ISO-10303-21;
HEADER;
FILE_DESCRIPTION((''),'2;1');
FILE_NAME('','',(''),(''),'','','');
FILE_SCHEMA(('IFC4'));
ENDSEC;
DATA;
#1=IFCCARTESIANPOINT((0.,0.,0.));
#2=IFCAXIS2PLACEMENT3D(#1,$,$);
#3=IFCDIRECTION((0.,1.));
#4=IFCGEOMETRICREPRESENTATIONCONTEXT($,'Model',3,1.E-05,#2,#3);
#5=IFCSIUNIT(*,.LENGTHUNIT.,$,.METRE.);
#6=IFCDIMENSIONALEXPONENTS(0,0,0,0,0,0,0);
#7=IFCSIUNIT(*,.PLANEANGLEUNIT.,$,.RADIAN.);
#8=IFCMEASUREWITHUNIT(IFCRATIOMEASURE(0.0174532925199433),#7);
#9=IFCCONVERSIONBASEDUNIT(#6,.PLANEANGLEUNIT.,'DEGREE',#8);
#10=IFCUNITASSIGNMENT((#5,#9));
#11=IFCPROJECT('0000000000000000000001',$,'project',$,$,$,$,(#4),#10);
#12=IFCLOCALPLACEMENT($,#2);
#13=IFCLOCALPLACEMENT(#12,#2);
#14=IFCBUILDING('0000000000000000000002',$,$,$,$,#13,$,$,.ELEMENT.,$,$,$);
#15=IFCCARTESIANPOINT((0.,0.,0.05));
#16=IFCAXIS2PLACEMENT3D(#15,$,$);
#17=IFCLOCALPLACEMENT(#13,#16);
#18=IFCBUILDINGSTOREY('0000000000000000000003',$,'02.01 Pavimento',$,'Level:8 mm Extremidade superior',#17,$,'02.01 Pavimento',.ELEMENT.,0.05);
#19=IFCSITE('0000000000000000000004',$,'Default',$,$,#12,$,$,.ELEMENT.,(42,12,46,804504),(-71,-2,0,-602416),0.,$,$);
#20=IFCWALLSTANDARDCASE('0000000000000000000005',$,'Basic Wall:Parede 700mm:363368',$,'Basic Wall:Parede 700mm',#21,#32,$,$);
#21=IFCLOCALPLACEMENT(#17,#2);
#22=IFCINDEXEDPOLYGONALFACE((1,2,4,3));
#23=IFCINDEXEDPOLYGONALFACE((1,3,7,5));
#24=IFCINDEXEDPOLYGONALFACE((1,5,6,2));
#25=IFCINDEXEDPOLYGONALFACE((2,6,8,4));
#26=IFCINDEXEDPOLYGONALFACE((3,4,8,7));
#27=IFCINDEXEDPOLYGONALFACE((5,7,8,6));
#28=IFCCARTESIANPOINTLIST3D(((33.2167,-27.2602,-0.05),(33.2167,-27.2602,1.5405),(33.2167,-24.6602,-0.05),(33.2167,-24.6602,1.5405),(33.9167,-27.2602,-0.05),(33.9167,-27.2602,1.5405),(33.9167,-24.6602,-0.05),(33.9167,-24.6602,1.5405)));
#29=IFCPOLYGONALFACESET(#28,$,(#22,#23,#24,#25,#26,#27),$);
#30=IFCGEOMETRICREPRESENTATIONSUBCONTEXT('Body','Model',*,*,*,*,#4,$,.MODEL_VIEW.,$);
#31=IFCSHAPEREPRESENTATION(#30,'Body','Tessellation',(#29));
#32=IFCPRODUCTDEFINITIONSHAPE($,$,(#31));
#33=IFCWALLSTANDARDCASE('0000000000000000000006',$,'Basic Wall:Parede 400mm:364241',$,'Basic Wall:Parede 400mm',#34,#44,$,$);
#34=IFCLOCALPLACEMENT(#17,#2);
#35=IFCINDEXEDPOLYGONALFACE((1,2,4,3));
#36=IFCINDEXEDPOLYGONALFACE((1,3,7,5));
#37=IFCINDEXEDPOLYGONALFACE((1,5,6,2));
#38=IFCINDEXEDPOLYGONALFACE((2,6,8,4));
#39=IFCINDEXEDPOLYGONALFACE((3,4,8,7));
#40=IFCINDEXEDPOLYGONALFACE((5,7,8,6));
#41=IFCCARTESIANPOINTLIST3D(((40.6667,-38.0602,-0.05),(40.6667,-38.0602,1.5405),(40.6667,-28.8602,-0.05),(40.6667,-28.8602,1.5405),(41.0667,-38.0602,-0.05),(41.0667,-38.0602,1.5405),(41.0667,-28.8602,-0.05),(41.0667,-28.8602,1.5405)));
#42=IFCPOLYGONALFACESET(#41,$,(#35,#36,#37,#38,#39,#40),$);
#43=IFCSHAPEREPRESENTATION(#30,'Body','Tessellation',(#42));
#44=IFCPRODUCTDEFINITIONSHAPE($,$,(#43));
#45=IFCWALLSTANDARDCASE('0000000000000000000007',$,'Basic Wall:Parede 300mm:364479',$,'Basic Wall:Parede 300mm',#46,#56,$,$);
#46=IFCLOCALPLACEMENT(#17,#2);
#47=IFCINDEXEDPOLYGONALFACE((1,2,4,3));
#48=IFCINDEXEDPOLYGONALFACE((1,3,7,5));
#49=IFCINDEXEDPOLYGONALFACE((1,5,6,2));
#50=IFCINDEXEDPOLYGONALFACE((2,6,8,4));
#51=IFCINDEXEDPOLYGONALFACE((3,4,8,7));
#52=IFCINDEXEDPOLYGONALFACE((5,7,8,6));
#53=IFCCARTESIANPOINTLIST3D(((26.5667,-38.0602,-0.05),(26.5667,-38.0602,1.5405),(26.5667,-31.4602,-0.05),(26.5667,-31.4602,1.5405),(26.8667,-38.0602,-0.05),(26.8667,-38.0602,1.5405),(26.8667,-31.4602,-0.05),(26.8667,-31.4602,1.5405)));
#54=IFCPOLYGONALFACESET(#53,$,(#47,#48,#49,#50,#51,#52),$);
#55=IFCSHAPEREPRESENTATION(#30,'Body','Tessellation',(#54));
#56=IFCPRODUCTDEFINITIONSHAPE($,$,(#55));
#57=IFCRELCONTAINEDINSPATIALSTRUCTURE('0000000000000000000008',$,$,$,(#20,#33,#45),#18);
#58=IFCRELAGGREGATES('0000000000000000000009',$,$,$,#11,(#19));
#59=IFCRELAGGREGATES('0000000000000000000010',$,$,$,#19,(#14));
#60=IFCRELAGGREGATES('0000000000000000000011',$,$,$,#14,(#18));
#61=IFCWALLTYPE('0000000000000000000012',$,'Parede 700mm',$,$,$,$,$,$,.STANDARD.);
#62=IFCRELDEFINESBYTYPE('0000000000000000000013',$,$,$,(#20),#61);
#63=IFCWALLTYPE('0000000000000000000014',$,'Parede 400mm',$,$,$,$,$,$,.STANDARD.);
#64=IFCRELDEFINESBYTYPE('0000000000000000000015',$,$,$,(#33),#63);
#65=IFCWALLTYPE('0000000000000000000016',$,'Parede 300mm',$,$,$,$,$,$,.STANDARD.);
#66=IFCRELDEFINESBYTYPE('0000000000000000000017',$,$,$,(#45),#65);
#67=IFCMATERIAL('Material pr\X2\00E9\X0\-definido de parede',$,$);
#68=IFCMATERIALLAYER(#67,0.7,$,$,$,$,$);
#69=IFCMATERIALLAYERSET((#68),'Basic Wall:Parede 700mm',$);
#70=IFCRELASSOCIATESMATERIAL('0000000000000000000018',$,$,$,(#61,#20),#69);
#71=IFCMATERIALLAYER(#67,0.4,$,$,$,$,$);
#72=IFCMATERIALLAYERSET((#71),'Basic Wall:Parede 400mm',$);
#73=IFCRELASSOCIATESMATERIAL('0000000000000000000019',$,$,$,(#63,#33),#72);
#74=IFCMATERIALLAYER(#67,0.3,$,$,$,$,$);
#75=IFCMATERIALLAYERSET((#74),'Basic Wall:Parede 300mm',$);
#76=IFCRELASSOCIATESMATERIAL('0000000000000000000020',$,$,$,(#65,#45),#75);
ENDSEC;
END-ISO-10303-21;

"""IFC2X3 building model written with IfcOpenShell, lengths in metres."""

from ifc_helpers import new_model, entity, si_unit, converted_unit, direction, frame, frame_2d, origin, place, context, subcontext, project, spatial, rectangle, extrude, clip, halfspace, material, layer, layer_set, layer_usage, type_object, element, save


model = new_model("IFC2X3")

# Units and contexts
model_context = context("Model", 3, precision=1e-05, world=origin(), true_north=direction((0.0, 1.0)))
body_context = subcontext(model_context, "Body", "Model", "MODEL_VIEW")
ifc_project = project(units=[si_unit("LENGTHUNIT", "METRE"), converted_unit("PLANEANGLEUNIT", "DEGREE", entity("IfcRatioMeasure", 0.0174532925199433), si_unit("PLANEANGLEUNIT", "RADIAN"), dimensions=[0, 0, 0, 0, 0, 0, 0])], contexts=[model_context])

# Site, building, storey
site_placement = place(None, origin())
site = spatial("IfcSite", under=ifc_project, at=site_placement, Name="Default", CompositionType="ELEMENT", RefLatitude=(42, 12, 46, 804504), RefLongitude=(-71, -2, 0, -602416), RefElevation=0.0)
building_placement = place(site_placement, origin())
building = spatial("IfcBuilding", under=site, at=building_placement, CompositionType="ELEMENT")
storey_placement = place(building_placement, frame((0.0, 0.0, 0.05)))
storey = spatial("IfcBuildingStorey", under=building, at=storey_placement, Name="02.01 Pavimento", ObjectType="Level:8 mm Extremidade superior", LongName="02.01 Pavimento", CompositionType="ELEMENT", Elevation=0.05)

# Shared definitions
ifc_material_1 = material(Name="Material pré-definido de parede")

# Wall
ifc_layer_1 = layer(ifc_material_1, 0.7)
ifc_layer_set_1 = layer_set([ifc_layer_1], Name="Basic Wall:Parede 700mm")
ifc_layer_usage_1 = layer_usage(ifc_layer_set_1, "AXIS2", "NEGATIVE", 0.35)
wall_type_1 = type_object("IfcWallType", Name="Parede 700mm", PredefinedType="STANDARD", material=ifc_layer_set_1)
wall_1_placement = place(storey_placement, frame((33.5667, -27.2602, -0.05), z_axis=(0.0, 0.0, 1.0), x_axis=(0.0, 1.0, 0.0)))
element("IfcWallStandardCase", 1, at=wall_1_placement, inside=storey, type_object=wall_type_1, material=ifc_layer_usage_1, Name="Basic Wall:Parede 700mm:363368", ObjectType="Basic Wall:Parede 700mm", context=body_context, shape_type="Clipping", body=[
    clip(extrude(rectangle(XDim=2.6, YDim=0.7, at=frame_2d((1.3, 0.0), x_axis=(-1.0, 0.0))), origin(), (0.0, 0.0, 1.0), 1.5905), halfspace(frame((0.0, 0.0, -0.05)), True)),
])

# Walls
ifc_layer_2 = layer(ifc_material_1, 0.4)
ifc_layer_set_2 = layer_set([ifc_layer_2], Name="Basic Wall:Parede 400mm")
ifc_layer_usage_2 = layer_usage(ifc_layer_set_2, "AXIS2", "NEGATIVE", 0.2)
wall_type_2 = type_object("IfcWallType", Name="Parede 400mm", PredefinedType="STANDARD", material=ifc_layer_set_2)
wall_2_placement = place(storey_placement, frame((40.8667, -38.0602, -0.05), z_axis=(0.0, 0.0, 1.0), x_axis=(0.0, 1.0, 0.0)))
element("IfcWallStandardCase", 2, at=wall_2_placement, inside=storey, type_object=wall_type_2, material=ifc_layer_usage_2, Name="Basic Wall:Parede 400mm:364241", ObjectType="Basic Wall:Parede 400mm", context=body_context, shape_type="Clipping", body=[
    clip(extrude(rectangle(XDim=0.4, YDim=9.2, at=frame_2d((4.6, 0.0), x_axis=(0.0, 1.0))), origin(), (0.0, 0.0, 1.0), 1.5905), halfspace(frame((0.0, 0.0, -0.05)), True)),
])
ifc_layer_3 = layer(ifc_material_1, 0.3)
ifc_layer_set_3 = layer_set([ifc_layer_3], Name="Basic Wall:Parede 300mm")
ifc_layer_usage_3 = layer_usage(ifc_layer_set_3, "AXIS2", "NEGATIVE", 0.15)
wall_type_3 = type_object("IfcWallType", Name="Parede 300mm", PredefinedType="STANDARD", material=ifc_layer_set_3)
wall_3_placement = place(storey_placement, frame((26.7167, -38.0602, -0.05), z_axis=(0.0, 0.0, 1.0), x_axis=(0.0, 1.0, 0.0)))
element("IfcWallStandardCase", 3, at=wall_3_placement, inside=storey, type_object=wall_type_3, material=ifc_layer_usage_3, Name="Basic Wall:Parede 300mm:364479", ObjectType="Basic Wall:Parede 300mm", context=body_context, shape_type="Clipping", body=[
    clip(extrude(rectangle(XDim=6.6, YDim=0.3, at=frame_2d((3.3, 0.0), x_axis=(-1.0, 0.0))), origin(), (0.0, 0.0, 1.0), 1.5905), halfspace(frame((0.0, 0.0, -0.05)), True)),
])

save(model, "model.ifc")
